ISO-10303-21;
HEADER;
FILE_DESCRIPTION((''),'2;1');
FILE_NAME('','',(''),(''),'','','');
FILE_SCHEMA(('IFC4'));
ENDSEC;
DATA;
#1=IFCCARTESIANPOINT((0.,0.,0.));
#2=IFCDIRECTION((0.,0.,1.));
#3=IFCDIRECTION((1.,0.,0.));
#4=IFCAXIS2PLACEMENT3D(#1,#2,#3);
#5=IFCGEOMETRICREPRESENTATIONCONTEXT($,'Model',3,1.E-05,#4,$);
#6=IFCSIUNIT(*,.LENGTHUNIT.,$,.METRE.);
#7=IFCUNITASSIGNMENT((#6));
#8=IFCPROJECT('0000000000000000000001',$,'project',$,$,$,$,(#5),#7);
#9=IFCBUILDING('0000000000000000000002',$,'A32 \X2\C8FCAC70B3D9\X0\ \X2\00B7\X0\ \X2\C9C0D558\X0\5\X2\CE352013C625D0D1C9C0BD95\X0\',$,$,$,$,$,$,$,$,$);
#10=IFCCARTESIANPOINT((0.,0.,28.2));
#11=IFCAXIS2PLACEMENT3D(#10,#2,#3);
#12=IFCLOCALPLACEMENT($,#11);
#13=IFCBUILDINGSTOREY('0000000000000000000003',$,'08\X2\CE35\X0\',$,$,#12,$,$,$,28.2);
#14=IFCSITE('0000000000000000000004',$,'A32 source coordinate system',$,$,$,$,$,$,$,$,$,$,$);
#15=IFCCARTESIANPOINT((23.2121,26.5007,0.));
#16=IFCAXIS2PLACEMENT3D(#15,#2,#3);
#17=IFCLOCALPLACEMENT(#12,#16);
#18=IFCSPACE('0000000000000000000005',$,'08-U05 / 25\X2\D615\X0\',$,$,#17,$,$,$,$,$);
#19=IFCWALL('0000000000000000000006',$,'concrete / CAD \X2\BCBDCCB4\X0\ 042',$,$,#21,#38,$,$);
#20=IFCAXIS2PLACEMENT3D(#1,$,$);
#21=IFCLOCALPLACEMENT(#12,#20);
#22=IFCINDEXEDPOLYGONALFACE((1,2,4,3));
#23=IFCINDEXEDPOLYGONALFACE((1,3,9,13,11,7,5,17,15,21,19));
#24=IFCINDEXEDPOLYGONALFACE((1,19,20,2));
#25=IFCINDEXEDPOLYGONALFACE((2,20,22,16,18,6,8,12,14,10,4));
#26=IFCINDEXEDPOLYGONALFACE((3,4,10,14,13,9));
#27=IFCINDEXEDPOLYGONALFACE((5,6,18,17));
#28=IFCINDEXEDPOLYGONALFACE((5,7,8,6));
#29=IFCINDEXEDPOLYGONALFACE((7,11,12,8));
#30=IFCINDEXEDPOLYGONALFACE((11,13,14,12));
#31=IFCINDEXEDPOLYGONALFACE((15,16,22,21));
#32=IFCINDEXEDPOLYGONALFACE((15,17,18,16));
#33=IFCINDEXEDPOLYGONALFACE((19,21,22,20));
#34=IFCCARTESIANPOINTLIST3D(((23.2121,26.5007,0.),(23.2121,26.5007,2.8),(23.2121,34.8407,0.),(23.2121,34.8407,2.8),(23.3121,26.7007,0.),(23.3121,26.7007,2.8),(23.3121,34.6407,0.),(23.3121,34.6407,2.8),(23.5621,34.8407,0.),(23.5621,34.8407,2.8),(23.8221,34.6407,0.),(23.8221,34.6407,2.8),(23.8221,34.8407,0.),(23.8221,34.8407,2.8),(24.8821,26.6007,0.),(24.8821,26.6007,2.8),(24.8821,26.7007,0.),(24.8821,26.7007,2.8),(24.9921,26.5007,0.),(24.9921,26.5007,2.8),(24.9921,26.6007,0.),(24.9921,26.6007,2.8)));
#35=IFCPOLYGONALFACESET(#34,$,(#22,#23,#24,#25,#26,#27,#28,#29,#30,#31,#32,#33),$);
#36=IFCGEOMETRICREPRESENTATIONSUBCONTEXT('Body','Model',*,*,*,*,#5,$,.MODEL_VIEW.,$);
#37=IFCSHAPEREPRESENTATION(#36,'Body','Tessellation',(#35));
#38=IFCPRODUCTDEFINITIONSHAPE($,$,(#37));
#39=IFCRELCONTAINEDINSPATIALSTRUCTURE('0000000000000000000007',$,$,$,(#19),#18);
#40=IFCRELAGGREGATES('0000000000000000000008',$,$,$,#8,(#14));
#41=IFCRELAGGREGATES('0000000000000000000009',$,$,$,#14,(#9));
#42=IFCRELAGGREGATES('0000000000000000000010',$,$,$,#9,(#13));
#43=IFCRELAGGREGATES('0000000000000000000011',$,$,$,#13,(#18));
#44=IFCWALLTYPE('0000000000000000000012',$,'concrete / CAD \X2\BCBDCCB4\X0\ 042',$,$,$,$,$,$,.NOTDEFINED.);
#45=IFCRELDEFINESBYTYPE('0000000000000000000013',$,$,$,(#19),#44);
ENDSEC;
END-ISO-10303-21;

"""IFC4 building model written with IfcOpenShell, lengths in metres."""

from ifc_helpers import new_model, si_unit, frame, origin, origin_with_axes, place, context, subcontext, project, spatial, polyline, outline, extrude, source, transform, mapped, type_object, type_shapes, element, save


model = new_model("IFC4")

# Units and contexts
model_context = context("Model", 3, precision=1e-05, world=origin_with_axes())
body_context = subcontext(model_context, "Body", "Model", "MODEL_VIEW")
ifc_project = project(units=[si_unit("LENGTHUNIT", "METRE")], contexts=[model_context])

# Site, building, storey, space
site = spatial("IfcSite", under=ifc_project, Name="A32 source coordinate system")
building = spatial("IfcBuilding", under=site, Name="A32 주거동 · 지하5층–옥탑지붕")
storey_placement = place(None, frame((0.0, 0.0, 28.2), z_axis=(0.0, 0.0, 1.0), x_axis=(1.0, 0.0, 0.0)))
storey = spatial("IfcBuildingStorey", under=building, at=storey_placement, Name="08층", Elevation=28.2)
space_1_placement = place(storey_placement, frame((23.2121, 26.5007, 0.0), z_axis=(0.0, 0.0, 1.0), x_axis=(1.0, 0.0, 0.0)))
space_1 = spatial("IfcSpace", under=storey, at=space_1_placement, Name="08-U05 / 25형")

# Wall
wall_type_1 = type_object("IfcWallType", Name="concrete / CAD 벽체 042", PredefinedType="NOTDEFINED")
shared_shape_1 = source(origin(), body_context, "Body", "SweptSolid", [
    extrude(outline(polyline([(0.1, 8.14), (0.1, 0.2), (1.67, 0.2), (1.67, 0.1), (1.78, 0.1), (1.78, 0.0), (0.0, 0.0), (0.0, 8.34), (0.35, 8.34), (0.35, 8.34), (0.61, 8.34), (0.61, 8.14), (0.1, 8.14)])), origin(), (0.0, 0.0, 1.0), 2.8),
])
type_shapes(wall_type_1, [shared_shape_1])
wall_1_placement = place(space_1_placement, origin_with_axes())
element("IfcWall", 1, at=wall_1_placement, inside=space_1, type_object=wall_type_1, Name="concrete / CAD 벽체 042", context=body_context, shape_type="MappedRepresentation", body=[
    mapped(shared_shape_1, transform((0.0, 0.0, 0.0), scale=1.0)),
])

save(model, "model.ifc")
